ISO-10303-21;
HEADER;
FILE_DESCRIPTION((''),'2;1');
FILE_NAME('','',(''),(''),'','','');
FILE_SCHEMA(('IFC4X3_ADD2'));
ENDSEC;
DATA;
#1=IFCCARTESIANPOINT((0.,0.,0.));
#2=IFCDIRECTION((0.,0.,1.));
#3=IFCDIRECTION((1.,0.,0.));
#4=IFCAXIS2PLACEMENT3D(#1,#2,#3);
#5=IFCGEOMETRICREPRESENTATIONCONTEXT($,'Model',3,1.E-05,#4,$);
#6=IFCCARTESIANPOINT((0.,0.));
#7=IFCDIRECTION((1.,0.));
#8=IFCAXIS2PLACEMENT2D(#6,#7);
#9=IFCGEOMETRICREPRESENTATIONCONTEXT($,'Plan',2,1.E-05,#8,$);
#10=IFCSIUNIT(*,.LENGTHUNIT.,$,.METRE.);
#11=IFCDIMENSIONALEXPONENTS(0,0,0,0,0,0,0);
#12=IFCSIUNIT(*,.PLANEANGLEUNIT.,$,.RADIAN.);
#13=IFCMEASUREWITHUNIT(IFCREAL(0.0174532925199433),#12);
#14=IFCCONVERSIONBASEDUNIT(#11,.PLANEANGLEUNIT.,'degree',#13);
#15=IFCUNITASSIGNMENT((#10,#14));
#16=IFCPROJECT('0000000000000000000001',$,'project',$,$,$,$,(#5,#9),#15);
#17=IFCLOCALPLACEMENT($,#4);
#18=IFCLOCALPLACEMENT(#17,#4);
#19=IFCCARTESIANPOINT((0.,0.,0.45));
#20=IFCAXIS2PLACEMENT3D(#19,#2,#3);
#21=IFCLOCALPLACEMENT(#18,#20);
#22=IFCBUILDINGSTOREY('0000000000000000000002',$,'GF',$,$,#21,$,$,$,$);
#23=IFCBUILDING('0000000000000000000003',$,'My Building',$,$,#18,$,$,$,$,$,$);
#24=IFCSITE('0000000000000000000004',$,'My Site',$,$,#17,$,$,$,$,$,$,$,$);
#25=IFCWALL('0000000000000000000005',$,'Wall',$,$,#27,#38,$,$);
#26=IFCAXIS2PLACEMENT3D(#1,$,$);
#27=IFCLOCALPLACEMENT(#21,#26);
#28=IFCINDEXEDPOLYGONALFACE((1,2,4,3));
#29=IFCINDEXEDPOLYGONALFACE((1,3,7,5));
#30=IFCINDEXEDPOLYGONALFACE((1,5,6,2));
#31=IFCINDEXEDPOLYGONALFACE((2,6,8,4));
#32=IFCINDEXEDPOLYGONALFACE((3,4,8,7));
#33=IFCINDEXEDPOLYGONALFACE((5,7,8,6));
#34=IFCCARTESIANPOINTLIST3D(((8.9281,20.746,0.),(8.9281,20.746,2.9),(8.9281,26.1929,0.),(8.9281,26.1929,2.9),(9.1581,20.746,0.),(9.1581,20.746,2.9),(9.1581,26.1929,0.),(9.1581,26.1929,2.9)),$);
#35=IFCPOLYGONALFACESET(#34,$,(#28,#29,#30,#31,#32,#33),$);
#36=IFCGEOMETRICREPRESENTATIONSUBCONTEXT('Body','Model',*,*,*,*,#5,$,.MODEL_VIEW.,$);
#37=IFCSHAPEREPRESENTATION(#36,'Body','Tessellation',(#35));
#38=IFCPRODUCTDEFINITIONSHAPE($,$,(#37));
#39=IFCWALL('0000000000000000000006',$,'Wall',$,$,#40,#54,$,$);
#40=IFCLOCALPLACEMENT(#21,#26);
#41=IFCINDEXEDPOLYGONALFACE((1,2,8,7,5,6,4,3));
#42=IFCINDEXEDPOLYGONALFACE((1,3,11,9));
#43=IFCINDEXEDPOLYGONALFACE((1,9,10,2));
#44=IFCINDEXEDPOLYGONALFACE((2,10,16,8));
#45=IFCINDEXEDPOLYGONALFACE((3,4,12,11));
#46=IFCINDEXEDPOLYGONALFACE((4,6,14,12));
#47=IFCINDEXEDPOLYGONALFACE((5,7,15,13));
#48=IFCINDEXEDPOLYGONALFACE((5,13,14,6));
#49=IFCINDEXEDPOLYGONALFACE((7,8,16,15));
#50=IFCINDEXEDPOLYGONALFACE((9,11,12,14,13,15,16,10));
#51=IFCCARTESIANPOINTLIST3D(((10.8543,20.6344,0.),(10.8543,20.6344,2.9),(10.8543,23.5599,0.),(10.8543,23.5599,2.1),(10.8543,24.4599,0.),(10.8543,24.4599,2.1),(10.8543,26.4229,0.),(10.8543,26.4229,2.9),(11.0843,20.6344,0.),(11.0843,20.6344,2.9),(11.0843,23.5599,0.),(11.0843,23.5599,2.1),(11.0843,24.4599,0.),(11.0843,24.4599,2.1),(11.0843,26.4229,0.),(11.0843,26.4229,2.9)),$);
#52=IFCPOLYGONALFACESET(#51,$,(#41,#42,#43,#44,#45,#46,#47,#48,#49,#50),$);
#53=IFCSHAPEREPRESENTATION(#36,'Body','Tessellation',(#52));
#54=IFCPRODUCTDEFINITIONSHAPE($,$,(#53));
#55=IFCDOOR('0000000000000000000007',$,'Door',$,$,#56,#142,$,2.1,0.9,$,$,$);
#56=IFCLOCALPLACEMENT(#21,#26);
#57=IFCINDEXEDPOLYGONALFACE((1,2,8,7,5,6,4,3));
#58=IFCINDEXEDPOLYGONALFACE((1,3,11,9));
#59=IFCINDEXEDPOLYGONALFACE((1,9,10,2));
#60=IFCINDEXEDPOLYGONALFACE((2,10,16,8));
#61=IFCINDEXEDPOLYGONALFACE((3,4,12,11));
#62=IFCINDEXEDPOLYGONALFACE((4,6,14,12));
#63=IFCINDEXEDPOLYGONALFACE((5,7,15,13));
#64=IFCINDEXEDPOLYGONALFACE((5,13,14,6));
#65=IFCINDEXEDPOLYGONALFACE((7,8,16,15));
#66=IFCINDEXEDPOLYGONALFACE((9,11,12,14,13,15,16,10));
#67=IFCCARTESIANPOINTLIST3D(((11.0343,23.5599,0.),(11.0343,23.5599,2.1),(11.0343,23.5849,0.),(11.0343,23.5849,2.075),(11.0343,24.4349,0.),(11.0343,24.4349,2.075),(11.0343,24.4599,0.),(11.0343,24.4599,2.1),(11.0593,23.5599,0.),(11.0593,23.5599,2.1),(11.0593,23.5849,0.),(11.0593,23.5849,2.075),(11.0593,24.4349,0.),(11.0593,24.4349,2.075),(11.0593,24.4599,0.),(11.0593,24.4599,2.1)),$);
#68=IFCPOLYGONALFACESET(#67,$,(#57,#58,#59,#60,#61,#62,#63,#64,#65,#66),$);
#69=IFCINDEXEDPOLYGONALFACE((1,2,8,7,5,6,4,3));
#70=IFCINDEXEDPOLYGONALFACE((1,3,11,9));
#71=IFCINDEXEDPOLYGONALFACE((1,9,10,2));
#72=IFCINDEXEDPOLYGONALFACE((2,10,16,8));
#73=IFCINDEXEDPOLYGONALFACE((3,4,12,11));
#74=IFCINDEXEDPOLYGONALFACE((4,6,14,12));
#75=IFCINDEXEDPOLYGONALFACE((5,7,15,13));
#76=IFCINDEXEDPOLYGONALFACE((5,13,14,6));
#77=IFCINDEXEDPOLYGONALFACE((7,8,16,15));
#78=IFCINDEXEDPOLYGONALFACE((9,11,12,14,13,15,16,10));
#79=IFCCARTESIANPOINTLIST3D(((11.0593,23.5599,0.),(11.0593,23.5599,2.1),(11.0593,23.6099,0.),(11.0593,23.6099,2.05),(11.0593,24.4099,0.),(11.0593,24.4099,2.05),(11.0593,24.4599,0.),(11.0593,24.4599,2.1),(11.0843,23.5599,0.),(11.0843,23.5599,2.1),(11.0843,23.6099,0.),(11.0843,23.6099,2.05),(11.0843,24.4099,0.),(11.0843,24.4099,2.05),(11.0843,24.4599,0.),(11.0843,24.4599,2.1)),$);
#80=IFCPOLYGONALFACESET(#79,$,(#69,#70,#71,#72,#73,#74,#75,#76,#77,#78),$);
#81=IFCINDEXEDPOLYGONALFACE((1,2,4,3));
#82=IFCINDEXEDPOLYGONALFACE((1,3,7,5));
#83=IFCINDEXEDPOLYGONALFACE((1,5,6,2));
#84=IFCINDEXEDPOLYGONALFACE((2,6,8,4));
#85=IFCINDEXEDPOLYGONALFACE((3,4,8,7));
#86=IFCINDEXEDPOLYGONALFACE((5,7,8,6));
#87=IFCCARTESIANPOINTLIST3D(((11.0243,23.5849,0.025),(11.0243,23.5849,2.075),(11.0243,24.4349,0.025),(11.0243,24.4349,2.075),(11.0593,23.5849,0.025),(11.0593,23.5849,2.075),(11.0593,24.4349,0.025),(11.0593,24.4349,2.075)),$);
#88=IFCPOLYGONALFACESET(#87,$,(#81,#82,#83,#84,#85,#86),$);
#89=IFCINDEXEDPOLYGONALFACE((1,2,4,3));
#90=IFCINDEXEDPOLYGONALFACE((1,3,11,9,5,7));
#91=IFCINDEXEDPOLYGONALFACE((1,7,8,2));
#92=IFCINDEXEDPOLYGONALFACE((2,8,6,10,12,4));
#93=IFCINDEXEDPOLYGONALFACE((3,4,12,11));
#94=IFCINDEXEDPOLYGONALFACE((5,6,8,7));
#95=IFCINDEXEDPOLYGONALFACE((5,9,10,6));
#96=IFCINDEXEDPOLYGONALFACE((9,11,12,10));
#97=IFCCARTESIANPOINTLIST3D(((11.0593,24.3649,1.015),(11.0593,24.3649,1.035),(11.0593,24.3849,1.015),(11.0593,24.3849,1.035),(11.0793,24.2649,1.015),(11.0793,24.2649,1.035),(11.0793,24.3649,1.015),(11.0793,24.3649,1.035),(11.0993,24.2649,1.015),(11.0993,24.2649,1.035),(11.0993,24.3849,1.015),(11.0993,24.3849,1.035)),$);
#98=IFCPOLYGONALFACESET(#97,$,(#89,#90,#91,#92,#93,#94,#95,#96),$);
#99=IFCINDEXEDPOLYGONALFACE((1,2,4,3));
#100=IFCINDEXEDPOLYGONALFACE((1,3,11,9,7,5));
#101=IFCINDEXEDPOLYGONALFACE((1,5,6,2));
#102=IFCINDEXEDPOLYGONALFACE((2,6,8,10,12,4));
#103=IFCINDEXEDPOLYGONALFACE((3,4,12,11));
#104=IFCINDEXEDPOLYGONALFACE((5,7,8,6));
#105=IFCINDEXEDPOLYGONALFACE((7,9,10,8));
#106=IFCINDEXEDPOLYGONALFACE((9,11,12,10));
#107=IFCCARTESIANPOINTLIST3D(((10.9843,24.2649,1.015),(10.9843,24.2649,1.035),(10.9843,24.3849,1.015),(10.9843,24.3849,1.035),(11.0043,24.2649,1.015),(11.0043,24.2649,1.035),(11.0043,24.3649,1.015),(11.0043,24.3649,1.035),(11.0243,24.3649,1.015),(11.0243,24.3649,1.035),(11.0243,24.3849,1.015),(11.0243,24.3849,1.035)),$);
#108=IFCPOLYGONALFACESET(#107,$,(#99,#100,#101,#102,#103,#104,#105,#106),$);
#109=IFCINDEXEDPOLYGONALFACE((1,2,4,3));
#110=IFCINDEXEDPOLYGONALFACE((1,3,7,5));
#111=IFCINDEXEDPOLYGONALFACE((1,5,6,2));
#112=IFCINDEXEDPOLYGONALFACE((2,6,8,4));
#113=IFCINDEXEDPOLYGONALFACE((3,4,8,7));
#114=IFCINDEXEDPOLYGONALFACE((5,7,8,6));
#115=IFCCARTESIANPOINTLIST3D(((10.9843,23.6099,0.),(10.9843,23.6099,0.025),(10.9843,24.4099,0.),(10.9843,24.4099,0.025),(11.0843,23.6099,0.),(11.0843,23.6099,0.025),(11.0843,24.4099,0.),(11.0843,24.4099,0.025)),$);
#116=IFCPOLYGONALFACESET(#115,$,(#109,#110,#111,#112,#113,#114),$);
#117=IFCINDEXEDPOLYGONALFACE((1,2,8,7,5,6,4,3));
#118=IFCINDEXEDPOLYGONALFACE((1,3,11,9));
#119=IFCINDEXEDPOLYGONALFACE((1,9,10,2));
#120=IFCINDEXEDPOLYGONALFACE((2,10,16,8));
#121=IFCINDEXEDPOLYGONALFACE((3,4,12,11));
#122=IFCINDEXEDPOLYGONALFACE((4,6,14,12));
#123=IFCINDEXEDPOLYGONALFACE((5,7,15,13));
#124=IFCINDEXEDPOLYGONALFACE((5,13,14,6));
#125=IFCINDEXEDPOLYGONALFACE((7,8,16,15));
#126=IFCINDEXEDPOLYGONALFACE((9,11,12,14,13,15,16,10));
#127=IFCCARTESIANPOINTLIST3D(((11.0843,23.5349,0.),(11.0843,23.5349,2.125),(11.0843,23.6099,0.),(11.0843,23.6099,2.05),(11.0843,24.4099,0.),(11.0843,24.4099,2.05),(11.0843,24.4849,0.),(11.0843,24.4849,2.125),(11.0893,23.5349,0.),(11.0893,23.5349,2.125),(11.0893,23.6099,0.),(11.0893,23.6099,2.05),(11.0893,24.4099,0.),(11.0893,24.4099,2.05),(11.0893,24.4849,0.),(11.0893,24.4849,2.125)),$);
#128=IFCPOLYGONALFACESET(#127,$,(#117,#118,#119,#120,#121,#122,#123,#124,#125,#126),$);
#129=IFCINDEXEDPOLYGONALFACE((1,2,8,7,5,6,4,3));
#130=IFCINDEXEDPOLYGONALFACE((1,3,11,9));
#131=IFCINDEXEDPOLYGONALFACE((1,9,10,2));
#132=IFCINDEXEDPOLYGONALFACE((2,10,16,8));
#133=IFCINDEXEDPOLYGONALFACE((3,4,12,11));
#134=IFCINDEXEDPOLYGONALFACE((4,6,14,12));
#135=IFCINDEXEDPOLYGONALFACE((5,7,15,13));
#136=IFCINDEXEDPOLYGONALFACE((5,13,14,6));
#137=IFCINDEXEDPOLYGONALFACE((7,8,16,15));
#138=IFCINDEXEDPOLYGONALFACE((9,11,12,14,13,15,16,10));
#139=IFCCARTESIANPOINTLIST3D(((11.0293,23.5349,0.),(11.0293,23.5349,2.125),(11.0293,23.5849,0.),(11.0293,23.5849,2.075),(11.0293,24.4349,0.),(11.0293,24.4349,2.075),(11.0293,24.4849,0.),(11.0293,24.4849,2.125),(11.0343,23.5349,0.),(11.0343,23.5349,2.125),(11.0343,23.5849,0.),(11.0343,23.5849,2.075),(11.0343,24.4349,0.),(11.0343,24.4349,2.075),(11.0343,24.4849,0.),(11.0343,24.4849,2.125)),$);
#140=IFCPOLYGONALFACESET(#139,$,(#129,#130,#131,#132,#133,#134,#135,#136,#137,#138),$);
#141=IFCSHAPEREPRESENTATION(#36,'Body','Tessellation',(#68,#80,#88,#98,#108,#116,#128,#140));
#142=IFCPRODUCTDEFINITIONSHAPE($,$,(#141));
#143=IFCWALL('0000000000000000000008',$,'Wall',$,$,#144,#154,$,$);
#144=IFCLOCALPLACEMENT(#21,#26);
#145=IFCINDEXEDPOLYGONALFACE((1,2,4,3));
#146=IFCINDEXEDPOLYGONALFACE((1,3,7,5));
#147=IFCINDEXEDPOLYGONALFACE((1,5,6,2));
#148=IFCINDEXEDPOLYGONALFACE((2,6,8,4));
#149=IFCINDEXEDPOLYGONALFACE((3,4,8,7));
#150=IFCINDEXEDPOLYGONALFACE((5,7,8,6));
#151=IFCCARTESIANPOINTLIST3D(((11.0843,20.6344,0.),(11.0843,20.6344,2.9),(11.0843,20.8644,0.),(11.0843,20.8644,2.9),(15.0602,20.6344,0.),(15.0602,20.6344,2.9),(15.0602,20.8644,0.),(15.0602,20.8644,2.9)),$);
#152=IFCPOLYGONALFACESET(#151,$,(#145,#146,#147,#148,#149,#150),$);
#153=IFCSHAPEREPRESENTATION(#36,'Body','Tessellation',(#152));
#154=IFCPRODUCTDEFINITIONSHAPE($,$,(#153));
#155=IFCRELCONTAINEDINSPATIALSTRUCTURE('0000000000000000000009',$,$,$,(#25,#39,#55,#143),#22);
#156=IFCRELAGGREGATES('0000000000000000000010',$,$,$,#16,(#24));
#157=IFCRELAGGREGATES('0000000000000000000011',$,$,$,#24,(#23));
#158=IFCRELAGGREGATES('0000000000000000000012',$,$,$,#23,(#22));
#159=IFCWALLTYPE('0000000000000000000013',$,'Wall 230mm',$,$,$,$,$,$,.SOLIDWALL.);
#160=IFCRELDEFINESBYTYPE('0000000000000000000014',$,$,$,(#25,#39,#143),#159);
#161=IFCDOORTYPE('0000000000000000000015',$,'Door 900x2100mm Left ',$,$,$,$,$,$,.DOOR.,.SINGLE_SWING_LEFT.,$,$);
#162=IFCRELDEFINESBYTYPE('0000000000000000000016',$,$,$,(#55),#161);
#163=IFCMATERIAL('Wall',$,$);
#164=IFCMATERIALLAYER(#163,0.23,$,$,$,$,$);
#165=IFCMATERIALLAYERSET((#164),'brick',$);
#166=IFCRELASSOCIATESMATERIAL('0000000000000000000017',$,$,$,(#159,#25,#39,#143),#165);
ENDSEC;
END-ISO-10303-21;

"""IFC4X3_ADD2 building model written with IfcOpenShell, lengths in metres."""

from ifc_helpers import new_model, entity, si_unit, converted_unit, frame, origin_with_axes, origin_2d_with_axis, place, context, subcontext, project, spatial, line, indexed_curve, outline, extrude, shape, source, transform, mapped, material, layer, layer_set, layer_usage, type_object, type_shapes, element, fill, save


model = new_model("IFC4X3_ADD2")

# Units and contexts
model_context = context("Model", 3, precision=1e-05, world=origin_with_axes())
plan_context = context("Plan", 2, precision=1e-05, world=origin_2d_with_axis())
body_context_1 = subcontext(model_context, "Body", "Model", "MODEL_VIEW")
body_context_2 = subcontext(plan_context, "Body", "Plan", "PLAN_VIEW")
ifc_project = project(units=[si_unit("LENGTHUNIT", "METRE"), converted_unit("PLANEANGLEUNIT", "degree", entity("IfcReal", 0.0174532925199433), si_unit("PLANEANGLEUNIT", "RADIAN"), dimensions=[0, 0, 0, 0, 0, 0, 0])], contexts=[model_context, plan_context])

# Site, building, storey
site_placement = place(None, origin_with_axes())
site = spatial("IfcSite", under=ifc_project, at=site_placement, Name="My Site")
building_placement = place(site_placement, origin_with_axes())
building = spatial("IfcBuilding", under=site, at=building_placement, Name="My Building")
storey_placement = place(building_placement, frame((0.0, 0.0, 0.45), z_axis=(0.0, 0.0, 1.0), x_axis=(1.0, 0.0, 0.0)))
storey = spatial("IfcBuildingStorey", under=building, at=storey_placement, Name="GF")

# Wall
ifc_material_1 = material(Name="Wall")
ifc_layer_1 = layer(ifc_material_1, 0.23)
ifc_layer_set_1 = layer_set([ifc_layer_1], Name="brick")
ifc_layer_usage_1 = layer_usage(ifc_layer_set_1, "AXIS2", "POSITIVE", 0.0)
wall_type_1 = type_object("IfcWallType", Name="Wall 230mm", PredefinedType="SOLIDWALL", material=ifc_layer_set_1)
wall_1_placement = place(storey_placement, frame((9.1581, 20.746, 0.0), z_axis=(0.0, 0.0, 1.0), x_axis=(0.0, 1.0, 0.0)))
element("IfcWall", 1, at=wall_1_placement, inside=storey, type_object=wall_type_1, material=ifc_layer_usage_1, Name="Wall", context=body_context_1, shape_type="SweptSolid", body=[
    extrude(outline(indexed_curve([(0.0, 0.0), (0.0, 0.23), (5.4469, 0.23), (5.4469, 0.0), (0.0, 0.0)], self_intersect=False)), origin_with_axes(), (0.0, 0.0, 1.0), 2.9),
])

# Wall, opening, door
ifc_layer_usage_2 = layer_usage(ifc_layer_set_1, "AXIS2", "POSITIVE", 0.0)
wall_2_placement = place(storey_placement, frame((11.0843, 20.6344, 0.0), z_axis=(0.0, 0.0, 1.0), x_axis=(0.0, 1.0, 0.0)))
wall_2 = element("IfcWall", 2, at=wall_2_placement, inside=storey, type_object=wall_type_1, material=ifc_layer_usage_2, Name="Wall", context=body_context_1, shape_type="SweptSolid", body=[
    extrude(outline(indexed_curve([(0.0, 0.0), (0.0, 0.23), (5.7885, 0.23), (5.7885, 0.0), (0.0, 0.0)], self_intersect=False)), origin_with_axes(), (0.0, 0.0, 1.0), 2.9),
])
shared_shape_1 = source(origin_with_axes(), body_context_1, "Body", "SweptSolid", [
    extrude(outline(indexed_curve([(0.0, 0.0), (0.9, 0.0), (0.9, 2.1), (0.0, 2.1)], segments=[line(1, 2, 3, 4, 1)])), frame((0.0, -0.6, 0.0), z_axis=(0.0, -1.0, 0.0), x_axis=(1.0, 0.0, 0.0)), (0.0, 0.0, -1.0), 1.2),
])
opening_1_placement = place(wall_2_placement, frame((2.9255, 0.0, 0.0), z_axis=(0.0, 0.0, 1.0), x_axis=(1.0, 0.0, 0.0)))
opening_1 = element("IfcOpeningElement", 3, at=opening_1_placement, cuts=wall_2, PredefinedType="OPENING", context=body_context_1, shape_type="MappedRepresentation", body=[
    mapped(shared_shape_1, transform((0.0, 0.0, 0.0), x_axis=(1.0, 0.0, 0.0), y_axis=(0.0, 1.0, 0.0), z_axis=(0.0, 0.0, 1.0), scale=1.0)),
])
door_type_1 = type_object("IfcDoorType", Name="Door 900x2100mm Left ", OperationType="SINGLE_SWING_LEFT", PredefinedType="DOOR")
shared_shape_2 = source(origin_with_axes(), body_context_1, "Body", "SweptSolid", [
    extrude(outline(indexed_curve([(0.0, 0.0), (0.0, 2.1), (0.9, 2.1), (0.9, 0.0), (0.875, 0.0), (0.875, 2.075), (0.025, 2.075), (0.025, 0.0)], segments=[line(1, 2, 3, 4, 5, 6, 7, 8, 1)])), frame((0.0, 0.025, 0.0), z_axis=(0.0, -1.0, 0.0), x_axis=(1.0, 0.0, 0.0)), (0.0, 0.0, -1.0), 0.025),
    extrude(outline(indexed_curve([(0.0, 0.0), (0.0, 2.1), (0.9, 2.1), (0.9, 0.0), (0.85, 0.0), (0.85, 2.05), (0.05, 2.05), (0.05, 0.0)], segments=[line(1, 2, 3, 4, 5, 6, 7, 8, 1)])), frame((0.0, 0.0, 0.0), z_axis=(0.0, -1.0, 0.0), x_axis=(1.0, 0.0, 0.0)), (0.0, 0.0, -1.0), 0.025),
    extrude(outline(indexed_curve([(0.0, 0.0), (0.85, 0.0), (0.85, 0.035), (0.0, 0.035)], segments=[line(1, 2, 3, 4, 1)])), frame((0.025, 0.025, 0.025), z_axis=(0.0, 0.0, 1.0), x_axis=(1.0, 0.0, 0.0)), (0.0, 0.0, 1.0), 2.05),
    extrude(outline(indexed_curve([(0.0, 0.0), (0.0, -0.04), (-0.12, -0.04), (-0.12, -0.02), (-0.02, -0.02), (-0.02, 0.0)], segments=[line(1, 2, 3, 4, 5, 6, 1)])), frame((0.825, 0.025, 1.015), z_axis=(0.0, 0.0, 1.0), x_axis=(1.0, 0.0, 0.0)), (0.0, 0.0, 1.0), 0.02),
    extrude(outline(indexed_curve([(0.0, 0.0), (0.0, 0.04), (-0.12, 0.04), (-0.12, 0.02), (-0.02, 0.02), (-0.02, 0.0)], segments=[line(1, 2, 3, 4, 5, 6, 1)])), frame((0.825, 0.06, 1.015), z_axis=(0.0, 0.0, 1.0), x_axis=(1.0, 0.0, 0.0)), (0.0, 0.0, 1.0), 0.02),
    extrude(outline(indexed_curve([(0.0, 0.0), (0.8, 0.0), (0.8, 0.1), (0.0, 0.1)], segments=[line(1, 2, 3, 4, 1)])), frame((0.05, 0.0, 0.0), z_axis=(0.0, 0.0, 1.0), x_axis=(1.0, 0.0, 0.0)), (0.0, 0.0, 1.0), 0.025),
    extrude(outline(indexed_curve([(0.0, 0.0), (0.0, 2.125), (0.95, 2.125), (0.95, 0.0), (0.875, 0.0), (0.875, 2.05), (0.075, 2.05), (0.075, 0.0)], segments=[line(1, 2, 3, 4, 5, 6, 7, 8, 1)])), frame((-0.025, -0.005, 0.0), z_axis=(0.0, -1.0, 0.0), x_axis=(1.0, 0.0, 0.0)), (0.0, 0.0, -1.0), 0.005),
    extrude(outline(indexed_curve([(0.0, 0.0), (0.0, 2.125), (0.95, 2.125), (0.95, 0.0), (0.9, 0.0), (0.9, 2.075), (0.05, 2.075), (0.05, 0.0)], segments=[line(1, 2, 3, 4, 5, 6, 7, 8, 1)])), frame((-0.025, 0.05, 0.0), z_axis=(0.0, -1.0, 0.0), x_axis=(1.0, 0.0, 0.0)), (0.0, 0.0, -1.0), 0.005),
])
shared_shape_3 = source(origin_with_axes(), body_context_2, "Body", "Curve2D", [
    entity("IfcIndexedPolyCurve", entity("IfcCartesianPointList2D", [[0.0, 0.0], [0.0, 0.05], [0.025, 0.05], [0.025, 0.025], [0.05, 0.025], [0.05, 0.0]]), [entity("IfcLineIndex", [1, 2, 3, 4, 5, 6, 1])]),
    entity("IfcIndexedPolyCurve", entity("IfcCartesianPointList2D", [[0.9, 0.0], [0.9, 0.05], [0.875, 0.05], [0.875, 0.025], [0.85, 0.025], [0.85, 0.0]]), [entity("IfcLineIndex", [1, 2, 3, 4, 5, 6, 1])]),
    entity("IfcTrimmedCurve", entity("IfcEllipse", entity("IfcAxis2Placement2D", entity("IfcCartesianPoint", [0.06, 0.05]), entity("IfcDirection", [1.0, 0.0])), 0.815, 0.85), [entity("IfcCartesianPoint", [0.875, 0.05])], [entity("IfcCartesianPoint", [0.06, 0.9])], True, "CARTESIAN"),
    entity("IfcIndexedPolyCurve", entity("IfcCartesianPointList2D", [[0.025, 0.05], [0.06, 0.05], [0.06, 0.9], [0.025, 0.9]]), [entity("IfcLineIndex", [1, 2, 3, 4, 1])]),
])
type_shapes(door_type_1, [shared_shape_2, shared_shape_3])
door_1_placement = place(opening_1_placement, origin_with_axes())
door_1 = element("IfcDoor", 4, at=door_1_placement, inside=storey, type_object=door_type_1, Name="Door", OverallHeight=2.1, OverallWidth=0.9, shapes=[
    shape(body_context_1, "Body", "MappedRepresentation", [mapped(shared_shape_2, transform((0.0, 0.0, 0.0), x_axis=(1.0, 0.0, 0.0), y_axis=(0.0, 1.0, 0.0), z_axis=(0.0, 0.0, 1.0), scale=1.0))]),
    shape(body_context_2, "Body", "MappedRepresentation", [mapped(shared_shape_3, transform((0.0, 0.0, 0.0), x_axis=(1.0, 0.0, 0.0), y_axis=(0.0, 1.0, 0.0), z_axis=(0.0, 0.0, 1.0), scale=1.0))]),
])
fill(opening_1, door_1)

# Wall
ifc_layer_usage_3 = layer_usage(ifc_layer_set_1, "AXIS2", "POSITIVE", 0.0)
wall_3_placement = place(storey_placement, frame((11.0843, 20.6344, 0.0), z_axis=(0.0, 0.0, 1.0), x_axis=(1.0, 0.0, 0.0)))
element("IfcWall", 5, at=wall_3_placement, inside=storey, type_object=wall_type_1, material=ifc_layer_usage_3, Name="Wall", context=body_context_1, shape_type="SweptSolid", body=[
    extrude(outline(indexed_curve([(0.0, 0.0), (0.0, 0.23), (3.9759, 0.23), (3.9759, 0.0), (0.0, 0.0)], self_intersect=False)), origin_with_axes(), (0.0, 0.0, 1.0), 2.9),
])

save(model, "model.ifc")
